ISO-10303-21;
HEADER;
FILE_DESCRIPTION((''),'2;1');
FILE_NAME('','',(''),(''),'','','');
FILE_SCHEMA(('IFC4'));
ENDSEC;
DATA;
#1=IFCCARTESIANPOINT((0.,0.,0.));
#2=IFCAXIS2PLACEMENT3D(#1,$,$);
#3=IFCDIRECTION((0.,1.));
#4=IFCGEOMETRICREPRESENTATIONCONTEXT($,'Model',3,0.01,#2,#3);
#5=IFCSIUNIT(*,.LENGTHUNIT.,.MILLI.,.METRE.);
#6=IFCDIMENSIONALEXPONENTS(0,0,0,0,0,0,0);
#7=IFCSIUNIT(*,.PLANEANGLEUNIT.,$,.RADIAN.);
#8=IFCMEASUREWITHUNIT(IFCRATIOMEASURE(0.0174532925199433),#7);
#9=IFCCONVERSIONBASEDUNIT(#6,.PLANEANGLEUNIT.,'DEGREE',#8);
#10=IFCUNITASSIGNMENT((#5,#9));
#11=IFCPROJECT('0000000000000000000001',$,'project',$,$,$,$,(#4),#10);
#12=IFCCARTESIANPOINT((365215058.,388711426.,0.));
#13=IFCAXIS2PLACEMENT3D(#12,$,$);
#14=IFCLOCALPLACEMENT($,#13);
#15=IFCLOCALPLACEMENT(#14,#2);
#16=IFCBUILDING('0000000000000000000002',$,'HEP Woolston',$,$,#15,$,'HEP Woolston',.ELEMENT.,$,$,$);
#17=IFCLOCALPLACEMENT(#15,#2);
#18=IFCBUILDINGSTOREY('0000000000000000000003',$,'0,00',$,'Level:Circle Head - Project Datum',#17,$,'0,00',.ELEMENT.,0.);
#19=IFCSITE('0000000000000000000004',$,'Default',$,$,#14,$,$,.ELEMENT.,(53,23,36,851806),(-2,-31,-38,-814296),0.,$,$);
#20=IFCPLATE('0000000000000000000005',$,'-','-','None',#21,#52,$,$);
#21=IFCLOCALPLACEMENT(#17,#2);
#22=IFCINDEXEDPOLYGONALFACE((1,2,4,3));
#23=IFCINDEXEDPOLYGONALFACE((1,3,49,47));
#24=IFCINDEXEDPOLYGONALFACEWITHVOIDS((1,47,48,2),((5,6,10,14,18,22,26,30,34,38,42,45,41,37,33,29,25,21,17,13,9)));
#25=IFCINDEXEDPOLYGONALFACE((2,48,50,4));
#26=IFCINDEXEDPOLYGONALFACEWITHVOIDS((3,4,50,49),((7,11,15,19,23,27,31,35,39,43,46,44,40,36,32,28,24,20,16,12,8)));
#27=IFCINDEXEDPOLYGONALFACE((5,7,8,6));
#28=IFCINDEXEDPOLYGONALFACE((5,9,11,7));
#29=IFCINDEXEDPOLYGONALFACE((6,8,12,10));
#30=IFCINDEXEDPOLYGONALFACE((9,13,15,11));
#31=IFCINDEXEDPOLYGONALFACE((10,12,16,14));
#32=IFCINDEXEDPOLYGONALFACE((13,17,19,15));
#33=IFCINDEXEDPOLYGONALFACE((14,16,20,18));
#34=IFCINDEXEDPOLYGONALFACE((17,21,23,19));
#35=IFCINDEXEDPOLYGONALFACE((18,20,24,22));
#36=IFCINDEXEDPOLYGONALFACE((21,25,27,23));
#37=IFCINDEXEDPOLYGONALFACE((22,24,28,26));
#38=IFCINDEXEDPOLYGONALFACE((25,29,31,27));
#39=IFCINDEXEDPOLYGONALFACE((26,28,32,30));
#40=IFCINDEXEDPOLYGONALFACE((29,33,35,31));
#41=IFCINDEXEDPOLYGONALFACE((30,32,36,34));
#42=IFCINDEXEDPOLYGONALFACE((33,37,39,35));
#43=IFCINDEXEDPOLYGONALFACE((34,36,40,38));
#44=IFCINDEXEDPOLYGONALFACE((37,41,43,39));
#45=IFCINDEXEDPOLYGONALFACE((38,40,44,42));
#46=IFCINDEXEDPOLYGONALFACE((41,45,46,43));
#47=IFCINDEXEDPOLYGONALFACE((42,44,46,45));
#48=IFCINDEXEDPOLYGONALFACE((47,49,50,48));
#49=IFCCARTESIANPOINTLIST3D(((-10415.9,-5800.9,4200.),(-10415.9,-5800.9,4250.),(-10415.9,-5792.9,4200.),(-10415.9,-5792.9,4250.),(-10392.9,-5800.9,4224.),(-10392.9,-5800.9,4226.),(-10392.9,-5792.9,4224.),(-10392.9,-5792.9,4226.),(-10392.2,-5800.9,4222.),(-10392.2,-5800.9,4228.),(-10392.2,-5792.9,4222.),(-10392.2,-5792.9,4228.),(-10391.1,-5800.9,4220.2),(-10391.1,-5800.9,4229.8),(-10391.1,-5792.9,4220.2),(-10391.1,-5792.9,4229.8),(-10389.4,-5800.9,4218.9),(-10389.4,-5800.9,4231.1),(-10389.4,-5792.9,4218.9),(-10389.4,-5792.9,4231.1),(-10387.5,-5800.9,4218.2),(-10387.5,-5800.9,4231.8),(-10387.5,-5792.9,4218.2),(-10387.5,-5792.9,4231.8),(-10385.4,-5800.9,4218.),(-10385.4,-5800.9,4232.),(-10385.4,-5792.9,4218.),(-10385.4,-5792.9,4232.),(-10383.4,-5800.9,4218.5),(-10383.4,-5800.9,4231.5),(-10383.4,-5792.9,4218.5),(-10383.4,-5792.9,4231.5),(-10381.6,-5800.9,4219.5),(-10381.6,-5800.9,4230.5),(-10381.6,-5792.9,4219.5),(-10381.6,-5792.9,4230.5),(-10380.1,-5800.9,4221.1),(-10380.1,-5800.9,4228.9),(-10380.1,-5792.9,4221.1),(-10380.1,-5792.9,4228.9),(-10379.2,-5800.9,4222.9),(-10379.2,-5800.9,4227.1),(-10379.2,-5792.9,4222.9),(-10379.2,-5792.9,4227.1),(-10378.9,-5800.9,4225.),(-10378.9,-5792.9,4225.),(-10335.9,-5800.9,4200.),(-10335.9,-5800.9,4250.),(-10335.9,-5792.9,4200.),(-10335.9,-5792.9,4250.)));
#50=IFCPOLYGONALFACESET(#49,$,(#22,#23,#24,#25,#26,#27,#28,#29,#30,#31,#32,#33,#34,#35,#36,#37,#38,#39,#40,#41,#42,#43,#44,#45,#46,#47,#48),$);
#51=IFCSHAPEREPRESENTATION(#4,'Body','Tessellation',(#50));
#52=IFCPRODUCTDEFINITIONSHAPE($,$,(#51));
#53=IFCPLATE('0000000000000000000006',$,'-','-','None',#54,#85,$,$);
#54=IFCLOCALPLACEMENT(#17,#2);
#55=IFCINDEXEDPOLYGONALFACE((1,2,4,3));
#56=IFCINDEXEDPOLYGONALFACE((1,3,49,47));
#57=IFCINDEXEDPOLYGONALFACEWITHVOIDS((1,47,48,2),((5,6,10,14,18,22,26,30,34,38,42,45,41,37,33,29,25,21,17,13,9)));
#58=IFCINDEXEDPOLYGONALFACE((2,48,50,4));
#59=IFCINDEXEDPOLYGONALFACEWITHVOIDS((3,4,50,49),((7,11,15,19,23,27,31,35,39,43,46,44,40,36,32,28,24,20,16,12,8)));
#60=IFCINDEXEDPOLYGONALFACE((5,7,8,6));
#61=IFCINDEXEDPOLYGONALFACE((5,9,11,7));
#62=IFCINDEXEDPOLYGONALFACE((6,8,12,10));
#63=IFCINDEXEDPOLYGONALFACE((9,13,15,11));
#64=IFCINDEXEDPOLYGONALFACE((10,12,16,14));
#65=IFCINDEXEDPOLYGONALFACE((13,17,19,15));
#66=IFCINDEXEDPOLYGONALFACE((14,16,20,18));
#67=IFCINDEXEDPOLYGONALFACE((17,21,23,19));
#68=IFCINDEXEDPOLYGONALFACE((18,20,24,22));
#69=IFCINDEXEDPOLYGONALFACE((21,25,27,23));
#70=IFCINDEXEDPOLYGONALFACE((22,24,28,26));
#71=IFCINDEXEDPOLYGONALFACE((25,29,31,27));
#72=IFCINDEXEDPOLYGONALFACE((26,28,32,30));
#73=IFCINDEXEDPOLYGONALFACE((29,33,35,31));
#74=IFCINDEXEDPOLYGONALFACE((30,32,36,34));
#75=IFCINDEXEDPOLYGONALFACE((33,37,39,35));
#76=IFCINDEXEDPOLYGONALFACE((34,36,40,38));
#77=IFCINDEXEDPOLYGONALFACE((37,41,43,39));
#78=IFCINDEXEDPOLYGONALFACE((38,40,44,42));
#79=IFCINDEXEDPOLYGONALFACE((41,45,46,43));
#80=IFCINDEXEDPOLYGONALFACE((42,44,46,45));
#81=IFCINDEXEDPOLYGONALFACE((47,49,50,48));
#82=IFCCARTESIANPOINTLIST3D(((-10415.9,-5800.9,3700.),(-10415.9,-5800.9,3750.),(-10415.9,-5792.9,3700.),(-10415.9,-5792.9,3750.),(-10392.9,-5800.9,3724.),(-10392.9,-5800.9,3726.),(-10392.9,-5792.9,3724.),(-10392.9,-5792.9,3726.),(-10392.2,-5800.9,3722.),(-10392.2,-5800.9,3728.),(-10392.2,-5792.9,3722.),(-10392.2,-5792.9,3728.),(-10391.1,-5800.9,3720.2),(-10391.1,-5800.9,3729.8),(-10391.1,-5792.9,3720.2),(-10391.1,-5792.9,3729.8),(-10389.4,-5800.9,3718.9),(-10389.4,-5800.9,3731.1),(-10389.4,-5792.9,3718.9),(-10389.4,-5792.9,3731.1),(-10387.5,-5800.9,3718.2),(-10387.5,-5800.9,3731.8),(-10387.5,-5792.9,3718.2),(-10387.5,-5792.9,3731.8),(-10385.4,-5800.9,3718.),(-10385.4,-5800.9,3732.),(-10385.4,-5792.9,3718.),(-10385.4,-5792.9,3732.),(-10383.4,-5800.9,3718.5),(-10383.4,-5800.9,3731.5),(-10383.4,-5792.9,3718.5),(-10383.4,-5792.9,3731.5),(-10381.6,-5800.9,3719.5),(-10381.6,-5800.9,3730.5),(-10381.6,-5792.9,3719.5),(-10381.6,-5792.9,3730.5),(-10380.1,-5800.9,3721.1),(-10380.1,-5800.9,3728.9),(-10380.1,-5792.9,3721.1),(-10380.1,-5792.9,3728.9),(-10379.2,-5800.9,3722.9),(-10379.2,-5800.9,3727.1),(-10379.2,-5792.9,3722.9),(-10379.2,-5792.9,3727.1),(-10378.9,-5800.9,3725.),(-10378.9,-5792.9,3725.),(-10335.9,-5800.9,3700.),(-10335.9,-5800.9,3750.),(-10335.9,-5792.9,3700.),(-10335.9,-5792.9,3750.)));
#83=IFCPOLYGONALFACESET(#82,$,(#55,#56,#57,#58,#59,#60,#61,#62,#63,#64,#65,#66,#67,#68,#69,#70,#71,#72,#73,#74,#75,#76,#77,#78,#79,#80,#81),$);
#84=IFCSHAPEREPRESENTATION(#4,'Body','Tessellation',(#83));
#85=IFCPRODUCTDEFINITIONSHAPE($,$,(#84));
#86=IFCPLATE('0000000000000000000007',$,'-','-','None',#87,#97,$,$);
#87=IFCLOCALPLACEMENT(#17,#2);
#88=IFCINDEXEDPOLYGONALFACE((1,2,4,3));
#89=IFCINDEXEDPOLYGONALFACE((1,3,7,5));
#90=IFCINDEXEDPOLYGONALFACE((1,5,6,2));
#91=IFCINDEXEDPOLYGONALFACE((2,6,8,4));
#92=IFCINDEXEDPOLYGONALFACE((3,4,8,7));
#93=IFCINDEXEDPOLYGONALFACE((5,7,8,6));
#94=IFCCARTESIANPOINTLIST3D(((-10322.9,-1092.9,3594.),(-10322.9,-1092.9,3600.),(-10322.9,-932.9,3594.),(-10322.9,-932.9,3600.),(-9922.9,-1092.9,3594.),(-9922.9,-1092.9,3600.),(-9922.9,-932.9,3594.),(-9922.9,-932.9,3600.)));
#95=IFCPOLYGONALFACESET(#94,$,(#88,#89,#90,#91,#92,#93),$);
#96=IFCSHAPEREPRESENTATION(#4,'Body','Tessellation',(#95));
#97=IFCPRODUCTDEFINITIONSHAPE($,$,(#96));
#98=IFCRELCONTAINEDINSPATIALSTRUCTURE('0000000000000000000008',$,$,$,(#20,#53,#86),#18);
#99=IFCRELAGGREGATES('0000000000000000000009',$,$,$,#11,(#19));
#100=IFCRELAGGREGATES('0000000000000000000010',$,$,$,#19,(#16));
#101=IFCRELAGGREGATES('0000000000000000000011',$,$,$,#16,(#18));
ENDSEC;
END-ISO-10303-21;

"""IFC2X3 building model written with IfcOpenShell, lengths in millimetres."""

from ifc_helpers import new_model, entity, si_unit, converted_unit, direction, frame, frame_2d, origin, origin_with_axes, place, context, project, spatial, polyline, circle, outline, extrude, element, save


model = new_model("IFC2X3")

# Units and contexts
model_context = context("Model", 3, precision=0.01, world=origin(), true_north=direction((0.0, 1.0)))
ifc_project = project(units=[si_unit("LENGTHUNIT", "METRE", prefix="MILLI"), converted_unit("PLANEANGLEUNIT", "DEGREE", entity("IfcRatioMeasure", 0.0174532925199433), si_unit("PLANEANGLEUNIT", "RADIAN"), dimensions=[0, 0, 0, 0, 0, 0, 0])], contexts=[model_context])

# Site, building, storey
site_placement = place(None, frame((365215058.0, 388711426.0, 0.0)))
site = spatial("IfcSite", under=ifc_project, at=site_placement, Name="Default", CompositionType="ELEMENT", RefLatitude=(53, 23, 36, 851806), RefLongitude=(-2, -31, -38, -814296), RefElevation=0.0)
building_placement = place(site_placement, origin())
building = spatial("IfcBuilding", under=site, at=building_placement, Name="HEP Woolston", LongName="HEP Woolston", CompositionType="ELEMENT")
storey_placement = place(building_placement, origin())
storey = spatial("IfcBuildingStorey", under=building, at=storey_placement, Name="0,00", ObjectType="Level:Circle Head - Project Datum", LongName="0,00", CompositionType="ELEMENT", Elevation=0.0)

# Plates, openings
plate_1_placement = place(storey_placement, frame((-10335.9, -5792.9, 4250.0), z_axis=(0.0, 1.0, 0.0), x_axis=(-1.0, 0.0, 0.0)))
plate_1 = element("IfcPlate", 1, at=plate_1_placement, inside=storey, Name="-", Description="-", ObjectType="None", context=model_context, shape_type="SweptSolid", body=[
    extrude(outline(polyline([(0.0, 0.0), (0.0, -50.0), (80.0, -50.0), (80.0, 0.0), (0.0, 0.0)])), origin_with_axes(), (0.0, 0.0, -1.0), 8.0),
])
opening_1_placement = place(plate_1_placement, frame((57.0, -25.0, -8.5), z_axis=(0.0, 0.0, -1.0), x_axis=(-1.0, 0.0, 0.0)))
element("IfcOpeningElement", 2, at=opening_1_placement, cuts=plate_1, ObjectType="Opening", context=model_context, shape_type="SweptSolid", body=[
    extrude(circle(Radius=7.0, at=frame_2d((7.0, 0.0), x_axis=(1.0, 0.0))), origin(), (0.0, 0.0, -1.0), 9.0),
])
plate_2_placement = place(storey_placement, frame((-10335.9, -5792.9, 3750.0), z_axis=(0.0, 1.0, 0.0), x_axis=(-1.0, 0.0, 0.0)))
plate_2 = element("IfcPlate", 3, at=plate_2_placement, inside=storey, Name="-", Description="-", ObjectType="None", context=model_context, shape_type="SweptSolid", body=[
    extrude(outline(polyline([(0.0, 0.0), (0.0, -50.0), (80.0, -50.0), (80.0, 0.0), (0.0, 0.0)])), origin_with_axes(), (0.0, 0.0, -1.0), 8.0),
])
opening_2_placement = place(plate_2_placement, frame((57.0, -25.0, -8.5), z_axis=(0.0, 0.0, -1.0), x_axis=(-1.0, 0.0, 0.0)))
element("IfcOpeningElement", 4, at=opening_2_placement, cuts=plate_2, ObjectType="Opening", context=model_context, shape_type="SweptSolid", body=[
    extrude(circle(Radius=7.0, at=frame_2d((7.0, 0.0), x_axis=(1.0, 0.0))), origin(), (0.0, 0.0, -1.0), 9.0),
])

# Plate
plate_3_placement = place(storey_placement, frame((-10322.9, -1092.9, 3594.0)))
element("IfcPlate", 5, at=plate_3_placement, inside=storey, Name="-", Description="-", ObjectType="None", context=model_context, shape_type="SweptSolid", body=[
    extrude(outline(polyline([(0.0, 0.0), (400.0, 0.0), (400.0, 160.0), (0.0, 160.0), (0.0, 0.0)])), origin_with_axes(), (0.0, 0.0, 1.0), 6.0),
])

save(model, "model.ifc")
